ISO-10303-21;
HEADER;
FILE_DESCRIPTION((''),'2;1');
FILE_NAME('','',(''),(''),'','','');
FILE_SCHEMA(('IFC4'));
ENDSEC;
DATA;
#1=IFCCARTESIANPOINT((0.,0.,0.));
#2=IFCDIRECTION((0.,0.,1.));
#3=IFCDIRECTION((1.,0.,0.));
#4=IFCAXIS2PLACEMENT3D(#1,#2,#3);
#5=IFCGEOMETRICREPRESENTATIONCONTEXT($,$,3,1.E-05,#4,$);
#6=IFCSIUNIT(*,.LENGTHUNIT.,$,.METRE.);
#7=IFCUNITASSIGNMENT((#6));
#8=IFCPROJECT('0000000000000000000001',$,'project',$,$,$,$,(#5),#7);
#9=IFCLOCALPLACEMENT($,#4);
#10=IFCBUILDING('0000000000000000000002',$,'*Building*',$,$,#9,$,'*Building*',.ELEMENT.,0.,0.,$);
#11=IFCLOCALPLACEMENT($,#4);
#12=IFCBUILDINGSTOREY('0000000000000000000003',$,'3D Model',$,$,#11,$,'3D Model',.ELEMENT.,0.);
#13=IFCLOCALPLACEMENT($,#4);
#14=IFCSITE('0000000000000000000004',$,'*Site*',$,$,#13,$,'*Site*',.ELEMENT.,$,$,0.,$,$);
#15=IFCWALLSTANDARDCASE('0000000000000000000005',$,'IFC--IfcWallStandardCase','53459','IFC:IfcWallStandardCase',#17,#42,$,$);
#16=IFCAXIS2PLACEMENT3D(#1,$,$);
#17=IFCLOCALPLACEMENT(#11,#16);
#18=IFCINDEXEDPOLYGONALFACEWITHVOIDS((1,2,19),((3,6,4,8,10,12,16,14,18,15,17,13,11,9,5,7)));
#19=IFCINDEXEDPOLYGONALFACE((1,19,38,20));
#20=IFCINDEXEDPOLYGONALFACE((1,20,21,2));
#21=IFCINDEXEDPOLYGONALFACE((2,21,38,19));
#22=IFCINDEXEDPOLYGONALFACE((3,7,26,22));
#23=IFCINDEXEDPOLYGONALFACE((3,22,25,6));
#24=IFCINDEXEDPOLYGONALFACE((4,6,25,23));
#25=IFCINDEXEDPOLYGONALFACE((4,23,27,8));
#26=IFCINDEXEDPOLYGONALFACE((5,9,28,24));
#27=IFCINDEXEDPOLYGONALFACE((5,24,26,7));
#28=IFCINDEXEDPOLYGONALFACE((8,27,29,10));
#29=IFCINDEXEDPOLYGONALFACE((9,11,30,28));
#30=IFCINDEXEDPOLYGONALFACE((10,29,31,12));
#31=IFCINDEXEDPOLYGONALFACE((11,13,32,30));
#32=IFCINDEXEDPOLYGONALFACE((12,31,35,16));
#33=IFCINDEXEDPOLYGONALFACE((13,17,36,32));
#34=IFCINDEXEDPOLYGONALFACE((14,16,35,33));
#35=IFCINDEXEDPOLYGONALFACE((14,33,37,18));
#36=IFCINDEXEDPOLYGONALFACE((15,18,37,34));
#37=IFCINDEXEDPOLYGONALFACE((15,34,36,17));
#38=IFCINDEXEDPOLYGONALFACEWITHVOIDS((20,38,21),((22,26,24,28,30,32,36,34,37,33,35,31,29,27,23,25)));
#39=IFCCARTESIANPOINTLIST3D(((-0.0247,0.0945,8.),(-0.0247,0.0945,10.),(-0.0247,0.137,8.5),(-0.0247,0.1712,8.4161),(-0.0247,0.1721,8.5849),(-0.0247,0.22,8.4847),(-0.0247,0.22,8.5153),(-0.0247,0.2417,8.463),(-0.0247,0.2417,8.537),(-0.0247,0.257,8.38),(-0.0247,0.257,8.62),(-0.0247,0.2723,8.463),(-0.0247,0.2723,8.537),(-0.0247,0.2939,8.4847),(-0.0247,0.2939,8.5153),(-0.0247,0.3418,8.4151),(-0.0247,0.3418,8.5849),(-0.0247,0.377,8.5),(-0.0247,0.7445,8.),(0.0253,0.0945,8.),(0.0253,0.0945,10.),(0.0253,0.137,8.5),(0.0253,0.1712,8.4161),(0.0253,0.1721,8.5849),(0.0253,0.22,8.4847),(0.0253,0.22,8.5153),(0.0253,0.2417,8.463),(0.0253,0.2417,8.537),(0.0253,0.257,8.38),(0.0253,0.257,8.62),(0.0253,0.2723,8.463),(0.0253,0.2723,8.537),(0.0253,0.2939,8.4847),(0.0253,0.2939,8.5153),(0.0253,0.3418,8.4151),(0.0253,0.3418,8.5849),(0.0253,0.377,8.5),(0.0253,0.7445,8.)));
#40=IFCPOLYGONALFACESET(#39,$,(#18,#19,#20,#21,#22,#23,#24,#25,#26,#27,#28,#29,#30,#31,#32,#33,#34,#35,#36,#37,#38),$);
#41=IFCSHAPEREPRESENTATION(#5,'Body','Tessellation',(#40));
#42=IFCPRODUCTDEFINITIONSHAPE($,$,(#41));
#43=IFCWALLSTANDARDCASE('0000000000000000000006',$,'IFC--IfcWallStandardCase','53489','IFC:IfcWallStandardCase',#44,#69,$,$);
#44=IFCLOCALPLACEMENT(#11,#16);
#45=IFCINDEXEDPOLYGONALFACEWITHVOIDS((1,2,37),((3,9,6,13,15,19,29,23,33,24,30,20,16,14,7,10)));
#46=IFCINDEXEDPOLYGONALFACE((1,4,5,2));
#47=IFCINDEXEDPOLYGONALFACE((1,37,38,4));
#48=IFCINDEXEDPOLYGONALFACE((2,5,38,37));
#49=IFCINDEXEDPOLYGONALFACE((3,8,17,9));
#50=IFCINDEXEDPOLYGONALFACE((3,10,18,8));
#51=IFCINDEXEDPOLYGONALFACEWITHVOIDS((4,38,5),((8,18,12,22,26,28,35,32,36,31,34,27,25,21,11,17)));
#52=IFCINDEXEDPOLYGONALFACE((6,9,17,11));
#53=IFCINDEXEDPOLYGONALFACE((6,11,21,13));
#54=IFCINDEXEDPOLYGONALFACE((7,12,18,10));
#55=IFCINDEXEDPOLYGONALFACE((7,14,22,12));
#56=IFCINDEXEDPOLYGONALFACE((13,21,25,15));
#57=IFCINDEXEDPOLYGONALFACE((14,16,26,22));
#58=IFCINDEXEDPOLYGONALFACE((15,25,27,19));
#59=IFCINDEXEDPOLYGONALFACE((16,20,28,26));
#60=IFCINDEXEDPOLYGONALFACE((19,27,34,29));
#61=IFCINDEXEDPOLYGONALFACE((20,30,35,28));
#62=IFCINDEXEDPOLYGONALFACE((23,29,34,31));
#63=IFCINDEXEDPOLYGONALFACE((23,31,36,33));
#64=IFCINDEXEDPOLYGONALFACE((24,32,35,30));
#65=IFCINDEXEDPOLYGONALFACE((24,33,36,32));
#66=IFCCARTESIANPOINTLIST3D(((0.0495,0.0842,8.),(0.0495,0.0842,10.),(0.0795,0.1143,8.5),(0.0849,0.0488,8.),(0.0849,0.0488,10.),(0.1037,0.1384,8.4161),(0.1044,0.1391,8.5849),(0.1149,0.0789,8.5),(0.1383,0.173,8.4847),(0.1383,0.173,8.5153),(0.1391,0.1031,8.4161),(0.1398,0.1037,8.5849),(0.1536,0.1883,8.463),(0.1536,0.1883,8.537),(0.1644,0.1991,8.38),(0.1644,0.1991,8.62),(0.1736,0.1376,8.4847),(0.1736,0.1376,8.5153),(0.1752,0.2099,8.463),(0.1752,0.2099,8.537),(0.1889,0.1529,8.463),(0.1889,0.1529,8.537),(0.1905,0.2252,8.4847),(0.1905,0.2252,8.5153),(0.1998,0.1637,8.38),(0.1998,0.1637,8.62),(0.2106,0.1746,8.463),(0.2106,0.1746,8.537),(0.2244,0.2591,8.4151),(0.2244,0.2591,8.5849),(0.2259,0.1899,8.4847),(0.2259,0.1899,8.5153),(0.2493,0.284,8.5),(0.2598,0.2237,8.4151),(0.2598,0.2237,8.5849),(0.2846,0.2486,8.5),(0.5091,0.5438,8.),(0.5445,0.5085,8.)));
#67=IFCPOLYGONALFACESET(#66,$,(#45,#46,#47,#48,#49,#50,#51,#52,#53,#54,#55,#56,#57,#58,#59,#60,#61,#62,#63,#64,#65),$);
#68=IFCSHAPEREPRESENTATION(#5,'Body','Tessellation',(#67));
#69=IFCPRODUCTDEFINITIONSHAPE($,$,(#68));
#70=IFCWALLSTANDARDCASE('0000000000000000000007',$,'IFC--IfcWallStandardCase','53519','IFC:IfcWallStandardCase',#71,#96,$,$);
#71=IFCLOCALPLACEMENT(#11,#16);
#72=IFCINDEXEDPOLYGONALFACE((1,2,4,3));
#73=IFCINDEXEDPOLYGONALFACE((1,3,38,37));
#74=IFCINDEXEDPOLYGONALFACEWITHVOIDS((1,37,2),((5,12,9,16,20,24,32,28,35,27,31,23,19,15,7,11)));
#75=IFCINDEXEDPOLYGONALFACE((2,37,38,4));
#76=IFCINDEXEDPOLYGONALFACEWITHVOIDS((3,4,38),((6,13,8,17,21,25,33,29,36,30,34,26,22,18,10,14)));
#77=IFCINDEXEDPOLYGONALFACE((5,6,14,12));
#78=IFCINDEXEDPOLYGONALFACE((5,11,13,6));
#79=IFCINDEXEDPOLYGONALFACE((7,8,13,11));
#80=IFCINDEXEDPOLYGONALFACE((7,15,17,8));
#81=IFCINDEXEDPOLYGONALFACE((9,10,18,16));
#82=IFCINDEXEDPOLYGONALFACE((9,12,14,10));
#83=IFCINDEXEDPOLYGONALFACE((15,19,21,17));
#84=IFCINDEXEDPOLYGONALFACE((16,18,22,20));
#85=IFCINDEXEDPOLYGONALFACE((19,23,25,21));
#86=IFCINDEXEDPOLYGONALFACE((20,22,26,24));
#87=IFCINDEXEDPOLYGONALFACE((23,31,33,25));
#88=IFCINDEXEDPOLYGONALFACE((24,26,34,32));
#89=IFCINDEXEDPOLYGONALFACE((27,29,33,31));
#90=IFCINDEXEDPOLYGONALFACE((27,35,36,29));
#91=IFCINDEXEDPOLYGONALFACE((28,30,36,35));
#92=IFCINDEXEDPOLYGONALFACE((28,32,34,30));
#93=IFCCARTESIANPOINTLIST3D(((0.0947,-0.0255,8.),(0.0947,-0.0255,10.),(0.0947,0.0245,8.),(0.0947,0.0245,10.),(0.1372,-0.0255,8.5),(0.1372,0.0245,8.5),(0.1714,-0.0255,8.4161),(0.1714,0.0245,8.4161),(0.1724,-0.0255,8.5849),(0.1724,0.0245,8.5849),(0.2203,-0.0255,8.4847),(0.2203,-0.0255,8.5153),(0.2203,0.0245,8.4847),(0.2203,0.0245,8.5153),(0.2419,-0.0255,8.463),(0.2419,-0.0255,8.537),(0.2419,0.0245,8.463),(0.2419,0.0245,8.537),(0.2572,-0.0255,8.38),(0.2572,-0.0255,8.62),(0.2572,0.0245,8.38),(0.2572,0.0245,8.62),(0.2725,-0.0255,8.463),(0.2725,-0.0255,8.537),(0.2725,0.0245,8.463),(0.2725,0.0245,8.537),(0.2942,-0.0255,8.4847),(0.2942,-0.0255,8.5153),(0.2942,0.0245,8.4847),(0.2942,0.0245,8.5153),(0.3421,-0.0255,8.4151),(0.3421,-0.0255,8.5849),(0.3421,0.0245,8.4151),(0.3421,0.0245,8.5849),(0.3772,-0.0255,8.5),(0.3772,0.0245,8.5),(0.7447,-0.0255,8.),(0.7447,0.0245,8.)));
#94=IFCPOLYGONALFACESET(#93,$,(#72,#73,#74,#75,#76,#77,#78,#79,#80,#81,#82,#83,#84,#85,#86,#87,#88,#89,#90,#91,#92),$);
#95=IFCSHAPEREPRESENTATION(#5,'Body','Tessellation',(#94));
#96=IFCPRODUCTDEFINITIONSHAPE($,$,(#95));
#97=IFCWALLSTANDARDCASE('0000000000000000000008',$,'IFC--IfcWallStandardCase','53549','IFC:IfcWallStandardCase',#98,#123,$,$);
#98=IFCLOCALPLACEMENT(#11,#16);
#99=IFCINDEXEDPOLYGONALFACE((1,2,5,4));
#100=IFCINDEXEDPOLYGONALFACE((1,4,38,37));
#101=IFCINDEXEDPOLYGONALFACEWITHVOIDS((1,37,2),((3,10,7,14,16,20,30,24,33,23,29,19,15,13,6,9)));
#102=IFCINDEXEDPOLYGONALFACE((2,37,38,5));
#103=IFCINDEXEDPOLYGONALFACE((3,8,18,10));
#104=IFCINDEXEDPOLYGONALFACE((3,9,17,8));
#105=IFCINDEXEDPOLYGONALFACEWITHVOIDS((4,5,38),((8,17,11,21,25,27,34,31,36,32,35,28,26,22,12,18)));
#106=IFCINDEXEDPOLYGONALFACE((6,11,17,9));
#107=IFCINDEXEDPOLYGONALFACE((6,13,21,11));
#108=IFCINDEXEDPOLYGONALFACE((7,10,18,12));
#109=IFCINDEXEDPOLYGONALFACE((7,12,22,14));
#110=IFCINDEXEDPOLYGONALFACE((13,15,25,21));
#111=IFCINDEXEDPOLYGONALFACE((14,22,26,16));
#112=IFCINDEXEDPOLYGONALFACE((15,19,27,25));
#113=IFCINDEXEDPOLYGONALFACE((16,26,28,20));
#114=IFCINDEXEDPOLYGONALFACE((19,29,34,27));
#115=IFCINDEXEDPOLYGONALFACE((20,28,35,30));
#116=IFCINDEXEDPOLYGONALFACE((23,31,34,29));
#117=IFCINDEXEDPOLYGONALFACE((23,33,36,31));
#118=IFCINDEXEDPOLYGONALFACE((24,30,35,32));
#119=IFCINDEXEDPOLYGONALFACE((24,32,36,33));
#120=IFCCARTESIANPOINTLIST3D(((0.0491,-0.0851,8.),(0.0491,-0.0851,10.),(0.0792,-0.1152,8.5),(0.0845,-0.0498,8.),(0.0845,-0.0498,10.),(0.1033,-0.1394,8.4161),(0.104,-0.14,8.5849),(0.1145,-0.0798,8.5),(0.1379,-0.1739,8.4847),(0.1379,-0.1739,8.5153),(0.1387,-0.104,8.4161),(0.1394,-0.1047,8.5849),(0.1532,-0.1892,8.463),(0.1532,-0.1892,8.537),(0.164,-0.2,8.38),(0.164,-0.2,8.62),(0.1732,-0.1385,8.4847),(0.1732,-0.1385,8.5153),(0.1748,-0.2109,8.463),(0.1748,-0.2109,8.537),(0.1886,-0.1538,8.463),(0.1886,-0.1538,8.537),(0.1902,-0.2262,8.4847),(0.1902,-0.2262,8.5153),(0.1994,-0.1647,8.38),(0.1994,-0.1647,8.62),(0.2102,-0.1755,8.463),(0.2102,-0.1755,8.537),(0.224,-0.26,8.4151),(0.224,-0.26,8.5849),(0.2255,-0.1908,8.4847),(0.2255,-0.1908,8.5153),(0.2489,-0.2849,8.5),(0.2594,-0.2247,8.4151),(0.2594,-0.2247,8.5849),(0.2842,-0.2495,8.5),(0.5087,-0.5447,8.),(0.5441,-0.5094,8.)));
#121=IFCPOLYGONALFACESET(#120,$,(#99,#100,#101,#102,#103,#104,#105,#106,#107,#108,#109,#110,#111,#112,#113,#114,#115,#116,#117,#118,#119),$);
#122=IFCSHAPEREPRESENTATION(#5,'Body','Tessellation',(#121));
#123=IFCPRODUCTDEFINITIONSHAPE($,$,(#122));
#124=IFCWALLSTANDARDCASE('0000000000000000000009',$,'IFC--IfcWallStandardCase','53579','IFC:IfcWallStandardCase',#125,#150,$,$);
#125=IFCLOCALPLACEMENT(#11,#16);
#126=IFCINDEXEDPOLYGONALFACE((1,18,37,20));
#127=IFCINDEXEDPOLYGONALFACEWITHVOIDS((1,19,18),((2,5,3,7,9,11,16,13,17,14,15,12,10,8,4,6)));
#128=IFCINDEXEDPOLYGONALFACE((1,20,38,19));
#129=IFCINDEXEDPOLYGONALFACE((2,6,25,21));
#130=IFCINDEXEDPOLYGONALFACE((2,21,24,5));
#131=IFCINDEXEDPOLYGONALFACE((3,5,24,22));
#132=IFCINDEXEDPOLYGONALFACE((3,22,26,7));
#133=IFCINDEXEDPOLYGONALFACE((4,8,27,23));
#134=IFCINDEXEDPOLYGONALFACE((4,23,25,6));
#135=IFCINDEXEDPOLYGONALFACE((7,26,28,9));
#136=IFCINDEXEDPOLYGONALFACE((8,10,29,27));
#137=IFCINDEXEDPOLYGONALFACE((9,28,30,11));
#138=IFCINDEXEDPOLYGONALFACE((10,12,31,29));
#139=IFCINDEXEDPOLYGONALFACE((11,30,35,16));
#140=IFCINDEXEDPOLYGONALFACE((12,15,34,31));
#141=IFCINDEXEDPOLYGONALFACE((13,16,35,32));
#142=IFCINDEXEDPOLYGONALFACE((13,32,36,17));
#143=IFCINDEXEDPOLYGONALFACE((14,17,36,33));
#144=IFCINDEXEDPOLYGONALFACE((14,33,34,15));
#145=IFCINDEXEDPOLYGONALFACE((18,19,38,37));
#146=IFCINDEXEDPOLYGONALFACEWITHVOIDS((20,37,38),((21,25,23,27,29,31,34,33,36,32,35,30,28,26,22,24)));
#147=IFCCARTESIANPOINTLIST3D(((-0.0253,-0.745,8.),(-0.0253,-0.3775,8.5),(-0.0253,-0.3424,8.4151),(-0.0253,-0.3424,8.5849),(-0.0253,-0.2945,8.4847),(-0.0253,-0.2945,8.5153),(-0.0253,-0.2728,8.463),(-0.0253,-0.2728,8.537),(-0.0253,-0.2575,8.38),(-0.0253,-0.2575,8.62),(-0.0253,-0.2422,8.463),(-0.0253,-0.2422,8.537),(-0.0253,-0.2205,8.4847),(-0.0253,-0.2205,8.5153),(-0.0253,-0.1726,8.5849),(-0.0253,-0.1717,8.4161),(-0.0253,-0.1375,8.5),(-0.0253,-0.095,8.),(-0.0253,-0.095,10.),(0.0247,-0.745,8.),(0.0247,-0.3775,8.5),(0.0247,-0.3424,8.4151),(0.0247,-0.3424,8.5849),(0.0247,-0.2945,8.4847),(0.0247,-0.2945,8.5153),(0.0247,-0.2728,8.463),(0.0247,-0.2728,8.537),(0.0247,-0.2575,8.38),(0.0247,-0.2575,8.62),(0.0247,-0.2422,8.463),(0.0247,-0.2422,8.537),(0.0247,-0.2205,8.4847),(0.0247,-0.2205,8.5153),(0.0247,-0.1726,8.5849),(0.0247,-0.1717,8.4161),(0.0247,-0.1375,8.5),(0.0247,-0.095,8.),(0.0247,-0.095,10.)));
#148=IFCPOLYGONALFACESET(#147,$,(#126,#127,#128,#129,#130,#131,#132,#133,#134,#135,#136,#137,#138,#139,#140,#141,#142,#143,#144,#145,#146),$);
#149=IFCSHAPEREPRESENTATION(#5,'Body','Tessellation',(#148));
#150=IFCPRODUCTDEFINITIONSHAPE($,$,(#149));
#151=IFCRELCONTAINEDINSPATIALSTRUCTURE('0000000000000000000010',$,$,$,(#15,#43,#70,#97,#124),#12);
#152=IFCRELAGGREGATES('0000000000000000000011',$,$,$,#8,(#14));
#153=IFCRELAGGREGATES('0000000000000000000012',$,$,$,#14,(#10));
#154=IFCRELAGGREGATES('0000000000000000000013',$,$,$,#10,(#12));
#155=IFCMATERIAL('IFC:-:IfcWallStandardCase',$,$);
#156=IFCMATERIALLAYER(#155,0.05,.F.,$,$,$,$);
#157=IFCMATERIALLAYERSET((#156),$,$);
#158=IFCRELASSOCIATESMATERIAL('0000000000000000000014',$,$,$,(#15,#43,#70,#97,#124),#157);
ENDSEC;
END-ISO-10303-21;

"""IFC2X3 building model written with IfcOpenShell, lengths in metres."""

from ifc_helpers import new_model, si_unit, frame, frame_2d, origin_with_axes, place, context, project, spatial, polyline, rectangle, outline, extrude, clip, halfspace, material, layer, layer_set, layer_usage, element, save


model = new_model("IFC2X3")

# Units and contexts
context_of_model = context(None, 3, precision=1e-05, world=origin_with_axes())
ifc_project = project(units=[si_unit("LENGTHUNIT", "METRE")], contexts=[context_of_model])

# Site, building, storey
site_placement = place(None, origin_with_axes())
site = spatial("IfcSite", under=ifc_project, at=site_placement, Name="*Site*", LongName="*Site*", CompositionType="ELEMENT", RefElevation=0.0)
building_placement = place(None, origin_with_axes())
building = spatial("IfcBuilding", under=site, at=building_placement, Name="*Building*", LongName="*Building*", CompositionType="ELEMENT", ElevationOfRefHeight=0.0, ElevationOfTerrain=0.0)
storey_placement = place(None, origin_with_axes())
storey = spatial("IfcBuildingStorey", under=building, at=storey_placement, Name="3D Model", LongName="3D Model", CompositionType="ELEMENT", Elevation=0.0)

# Walls, openings
ifc_material = material(Name="IFC:-:IfcWallStandardCase")
ifc_layer = layer(ifc_material, 0.05, ventilated=False)
ifc_layer_set = layer_set([ifc_layer])
ifc_layer_usage = layer_usage(ifc_layer_set, "AXIS2", "POSITIVE", 0.0)
wall_1_placement = place(None, frame((0.0003, 0.0945, 8.0), z_axis=(0.0, 0.0, 1.0), x_axis=(-0.000003, 1.0, 0.0)))
wall_1 = element("IfcWallStandardCase", 1, at=wall_1_placement, inside=storey, material=ifc_layer_usage, Name="IFC--IfcWallStandardCase", Description="53459", ObjectType="IFC:IfcWallStandardCase", context=context_of_model, shape_type="Clipping", body=[
    clip(extrude(rectangle(XDim=0.65, YDim=0.05, at=frame_2d((0.325, 0.0), x_axis=(1.0, 0.0))), origin_with_axes(), (0.0, 0.0, 1.0), 2.0), halfspace(frame((0.5879, 0.0, 0.1911), z_axis=(-0.951034, 0.000003, -0.309086), x_axis=(-0.000003, -1.0, 0.0)), True)),
])
opening_1_placement = place(wall_1_placement, frame((0.0425, 0.025, 0.38), z_axis=(0.0, 0.0, 1.0), x_axis=(1.0, 0.0, 0.0)))
element("IfcOpeningElement", 2, at=opening_1_placement, cuts=wall_1, context=context_of_model, shape_type="SweptSolid", body=[
    extrude(outline(polyline([(-0.157, 0.1047), (-0.2049, 0.0351), (-0.1353, 0.083), (-0.12, 0.0), (-0.1047, 0.083), (-0.0342, 0.0361), (-0.083, 0.1047), (0.0, 0.12), (-0.083, 0.1353), (-0.0351, 0.2049), (-0.1047, 0.157), (-0.12, 0.24), (-0.1353, 0.157), (-0.2049, 0.2049), (-0.157, 0.1353), (-0.24, 0.12), (-0.157, 0.1047)])), frame((0.0, 0.0, 0.0), z_axis=(0.0, 1.0, 0.0), x_axis=(-1.0, 0.0, 0.0)), (0.0, 0.0, -1.0), 0.15),
])
wall_2_placement = place(None, frame((0.0672, 0.0665, 8.0), z_axis=(0.0, 0.0, 1.0), x_axis=(0.707105, 0.707109, 0.0)))
wall_2 = element("IfcWallStandardCase", 3, at=wall_2_placement, inside=storey, material=ifc_layer_usage, Name="IFC--IfcWallStandardCase", Description="53489", ObjectType="IFC:IfcWallStandardCase", context=context_of_model, shape_type="Clipping", body=[
    clip(extrude(rectangle(XDim=0.65, YDim=0.05, at=frame_2d((0.325, 0.0), x_axis=(1.0, 0.0))), origin_with_axes(), (0.0, 0.0, 1.0), 2.0), halfspace(frame((0.5879, 0.0, 0.1911), z_axis=(-0.951034, 0.000003, -0.309086), x_axis=(-0.000003, -1.0, 0.0)), True)),
])
opening_2_placement = place(wall_2_placement, frame((0.0425, 0.025, 0.38), z_axis=(0.0, 0.0, 1.0), x_axis=(1.0, 0.0, 0.0)))
element("IfcOpeningElement", 4, at=opening_2_placement, cuts=wall_2, context=context_of_model, shape_type="SweptSolid", body=[
    extrude(outline(polyline([(-0.157, 0.1047), (-0.2049, 0.0351), (-0.1353, 0.083), (-0.12, 0.0), (-0.1047, 0.083), (-0.0342, 0.0361), (-0.083, 0.1047), (0.0, 0.12), (-0.083, 0.1353), (-0.0351, 0.2049), (-0.1047, 0.157), (-0.12, 0.24), (-0.1353, 0.157), (-0.2049, 0.2049), (-0.157, 0.1353), (-0.24, 0.12), (-0.157, 0.1047)])), frame((0.0, 0.0, 0.0), z_axis=(0.0, 1.0, 0.0), x_axis=(-1.0, 0.0, 0.0)), (0.0, 0.0, -1.0), 0.15),
])
wall_3_placement = place(None, frame((0.0947, -0.0005, 8.0), z_axis=(0.0, 0.0, 1.0), x_axis=(1.0, 0.000003, 0.0)))
wall_3 = element("IfcWallStandardCase", 5, at=wall_3_placement, inside=storey, material=ifc_layer_usage, Name="IFC--IfcWallStandardCase", Description="53519", ObjectType="IFC:IfcWallStandardCase", context=context_of_model, shape_type="Clipping", body=[
    clip(extrude(rectangle(XDim=0.65, YDim=0.05, at=frame_2d((0.325, 0.0), x_axis=(1.0, 0.0))), origin_with_axes(), (0.0, 0.0, 1.0), 2.0), halfspace(frame((0.5879, 0.0, 0.1911), z_axis=(-0.951034, 0.000003, -0.309086), x_axis=(-0.000003, -1.0, 0.0)), True)),
])
opening_3_placement = place(wall_3_placement, frame((0.0425, 0.025, 0.38), z_axis=(0.0, 0.0, 1.0), x_axis=(1.0, 0.0, 0.0)))
element("IfcOpeningElement", 6, at=opening_3_placement, cuts=wall_3, context=context_of_model, shape_type="SweptSolid", body=[
    extrude(outline(polyline([(-0.157, 0.1047), (-0.2049, 0.0351), (-0.1353, 0.083), (-0.12, 0.0), (-0.1047, 0.083), (-0.0342, 0.0361), (-0.083, 0.1047), (0.0, 0.12), (-0.083, 0.1353), (-0.0351, 0.2049), (-0.1047, 0.157), (-0.12, 0.24), (-0.1353, 0.157), (-0.2049, 0.2049), (-0.157, 0.1353), (-0.24, 0.12), (-0.157, 0.1047)])), frame((0.0, 0.0, 0.0), z_axis=(0.0, 1.0, 0.0), x_axis=(-1.0, 0.0, 0.0)), (0.0, 0.0, -1.0), 0.15),
])
wall_4_placement = place(None, frame((0.0668, -0.0674, 8.0), z_axis=(0.0, 0.0, 1.0), x_axis=(0.707109, -0.707105, 0.0)))
wall_4 = element("IfcWallStandardCase", 7, at=wall_4_placement, inside=storey, material=ifc_layer_usage, Name="IFC--IfcWallStandardCase", Description="53549", ObjectType="IFC:IfcWallStandardCase", context=context_of_model, shape_type="Clipping", body=[
    clip(extrude(rectangle(XDim=0.65, YDim=0.05, at=frame_2d((0.325, 0.0), x_axis=(1.0, 0.0))), origin_with_axes(), (0.0, 0.0, 1.0), 2.0), halfspace(frame((0.5879, 0.0, 0.1911), z_axis=(-0.951034, 0.000003, -0.309086), x_axis=(-0.000003, -1.0, 0.0)), True)),
])
opening_4_placement = place(wall_4_placement, frame((0.0425, 0.025, 0.38), z_axis=(0.0, 0.0, 1.0), x_axis=(1.0, 0.0, 0.0)))
element("IfcOpeningElement", 8, at=opening_4_placement, cuts=wall_4, context=context_of_model, shape_type="SweptSolid", body=[
    extrude(outline(polyline([(-0.157, 0.1047), (-0.2049, 0.0351), (-0.1353, 0.083), (-0.12, 0.0), (-0.1047, 0.083), (-0.0342, 0.0361), (-0.083, 0.1047), (0.0, 0.12), (-0.083, 0.1353), (-0.0351, 0.2049), (-0.1047, 0.157), (-0.12, 0.24), (-0.1353, 0.157), (-0.2049, 0.2049), (-0.157, 0.1353), (-0.24, 0.12), (-0.157, 0.1047)])), frame((0.0, 0.0, 0.0), z_axis=(0.0, 1.0, 0.0), x_axis=(-1.0, 0.0, 0.0)), (0.0, 0.0, -1.0), 0.15),
])
wall_5_placement = place(None, frame((-0.0003, -0.095, 8.0), z_axis=(0.0, 0.0, 1.0), x_axis=(0.000003, -1.0, 0.0)))
wall_5 = element("IfcWallStandardCase", 9, at=wall_5_placement, inside=storey, material=ifc_layer_usage, Name="IFC--IfcWallStandardCase", Description="53579", ObjectType="IFC:IfcWallStandardCase", context=context_of_model, shape_type="Clipping", body=[
    clip(extrude(rectangle(XDim=0.65, YDim=0.05, at=frame_2d((0.325, 0.0), x_axis=(1.0, 0.0))), origin_with_axes(), (0.0, 0.0, 1.0), 2.0), halfspace(frame((0.5879, 0.0, 0.1911), z_axis=(-0.951034, 0.000003, -0.309086), x_axis=(-0.000003, -1.0, 0.0)), True)),
])
opening_5_placement = place(wall_5_placement, frame((0.0425, 0.025, 0.38), z_axis=(0.0, 0.0, 1.0), x_axis=(1.0, 0.0, 0.0)))
element("IfcOpeningElement", 10, at=opening_5_placement, cuts=wall_5, context=context_of_model, shape_type="SweptSolid", body=[
    extrude(outline(polyline([(-0.157, 0.1047), (-0.2049, 0.0351), (-0.1353, 0.083), (-0.12, 0.0), (-0.1047, 0.083), (-0.0342, 0.0361), (-0.083, 0.1047), (0.0, 0.12), (-0.083, 0.1353), (-0.0351, 0.2049), (-0.1047, 0.157), (-0.12, 0.24), (-0.1353, 0.157), (-0.2049, 0.2049), (-0.157, 0.1353), (-0.24, 0.12), (-0.157, 0.1047)])), frame((0.0, 0.0, 0.0), z_axis=(0.0, 1.0, 0.0), x_axis=(-1.0, 0.0, 0.0)), (0.0, 0.0, -1.0), 0.15),
])

save(model, "model.ifc")
